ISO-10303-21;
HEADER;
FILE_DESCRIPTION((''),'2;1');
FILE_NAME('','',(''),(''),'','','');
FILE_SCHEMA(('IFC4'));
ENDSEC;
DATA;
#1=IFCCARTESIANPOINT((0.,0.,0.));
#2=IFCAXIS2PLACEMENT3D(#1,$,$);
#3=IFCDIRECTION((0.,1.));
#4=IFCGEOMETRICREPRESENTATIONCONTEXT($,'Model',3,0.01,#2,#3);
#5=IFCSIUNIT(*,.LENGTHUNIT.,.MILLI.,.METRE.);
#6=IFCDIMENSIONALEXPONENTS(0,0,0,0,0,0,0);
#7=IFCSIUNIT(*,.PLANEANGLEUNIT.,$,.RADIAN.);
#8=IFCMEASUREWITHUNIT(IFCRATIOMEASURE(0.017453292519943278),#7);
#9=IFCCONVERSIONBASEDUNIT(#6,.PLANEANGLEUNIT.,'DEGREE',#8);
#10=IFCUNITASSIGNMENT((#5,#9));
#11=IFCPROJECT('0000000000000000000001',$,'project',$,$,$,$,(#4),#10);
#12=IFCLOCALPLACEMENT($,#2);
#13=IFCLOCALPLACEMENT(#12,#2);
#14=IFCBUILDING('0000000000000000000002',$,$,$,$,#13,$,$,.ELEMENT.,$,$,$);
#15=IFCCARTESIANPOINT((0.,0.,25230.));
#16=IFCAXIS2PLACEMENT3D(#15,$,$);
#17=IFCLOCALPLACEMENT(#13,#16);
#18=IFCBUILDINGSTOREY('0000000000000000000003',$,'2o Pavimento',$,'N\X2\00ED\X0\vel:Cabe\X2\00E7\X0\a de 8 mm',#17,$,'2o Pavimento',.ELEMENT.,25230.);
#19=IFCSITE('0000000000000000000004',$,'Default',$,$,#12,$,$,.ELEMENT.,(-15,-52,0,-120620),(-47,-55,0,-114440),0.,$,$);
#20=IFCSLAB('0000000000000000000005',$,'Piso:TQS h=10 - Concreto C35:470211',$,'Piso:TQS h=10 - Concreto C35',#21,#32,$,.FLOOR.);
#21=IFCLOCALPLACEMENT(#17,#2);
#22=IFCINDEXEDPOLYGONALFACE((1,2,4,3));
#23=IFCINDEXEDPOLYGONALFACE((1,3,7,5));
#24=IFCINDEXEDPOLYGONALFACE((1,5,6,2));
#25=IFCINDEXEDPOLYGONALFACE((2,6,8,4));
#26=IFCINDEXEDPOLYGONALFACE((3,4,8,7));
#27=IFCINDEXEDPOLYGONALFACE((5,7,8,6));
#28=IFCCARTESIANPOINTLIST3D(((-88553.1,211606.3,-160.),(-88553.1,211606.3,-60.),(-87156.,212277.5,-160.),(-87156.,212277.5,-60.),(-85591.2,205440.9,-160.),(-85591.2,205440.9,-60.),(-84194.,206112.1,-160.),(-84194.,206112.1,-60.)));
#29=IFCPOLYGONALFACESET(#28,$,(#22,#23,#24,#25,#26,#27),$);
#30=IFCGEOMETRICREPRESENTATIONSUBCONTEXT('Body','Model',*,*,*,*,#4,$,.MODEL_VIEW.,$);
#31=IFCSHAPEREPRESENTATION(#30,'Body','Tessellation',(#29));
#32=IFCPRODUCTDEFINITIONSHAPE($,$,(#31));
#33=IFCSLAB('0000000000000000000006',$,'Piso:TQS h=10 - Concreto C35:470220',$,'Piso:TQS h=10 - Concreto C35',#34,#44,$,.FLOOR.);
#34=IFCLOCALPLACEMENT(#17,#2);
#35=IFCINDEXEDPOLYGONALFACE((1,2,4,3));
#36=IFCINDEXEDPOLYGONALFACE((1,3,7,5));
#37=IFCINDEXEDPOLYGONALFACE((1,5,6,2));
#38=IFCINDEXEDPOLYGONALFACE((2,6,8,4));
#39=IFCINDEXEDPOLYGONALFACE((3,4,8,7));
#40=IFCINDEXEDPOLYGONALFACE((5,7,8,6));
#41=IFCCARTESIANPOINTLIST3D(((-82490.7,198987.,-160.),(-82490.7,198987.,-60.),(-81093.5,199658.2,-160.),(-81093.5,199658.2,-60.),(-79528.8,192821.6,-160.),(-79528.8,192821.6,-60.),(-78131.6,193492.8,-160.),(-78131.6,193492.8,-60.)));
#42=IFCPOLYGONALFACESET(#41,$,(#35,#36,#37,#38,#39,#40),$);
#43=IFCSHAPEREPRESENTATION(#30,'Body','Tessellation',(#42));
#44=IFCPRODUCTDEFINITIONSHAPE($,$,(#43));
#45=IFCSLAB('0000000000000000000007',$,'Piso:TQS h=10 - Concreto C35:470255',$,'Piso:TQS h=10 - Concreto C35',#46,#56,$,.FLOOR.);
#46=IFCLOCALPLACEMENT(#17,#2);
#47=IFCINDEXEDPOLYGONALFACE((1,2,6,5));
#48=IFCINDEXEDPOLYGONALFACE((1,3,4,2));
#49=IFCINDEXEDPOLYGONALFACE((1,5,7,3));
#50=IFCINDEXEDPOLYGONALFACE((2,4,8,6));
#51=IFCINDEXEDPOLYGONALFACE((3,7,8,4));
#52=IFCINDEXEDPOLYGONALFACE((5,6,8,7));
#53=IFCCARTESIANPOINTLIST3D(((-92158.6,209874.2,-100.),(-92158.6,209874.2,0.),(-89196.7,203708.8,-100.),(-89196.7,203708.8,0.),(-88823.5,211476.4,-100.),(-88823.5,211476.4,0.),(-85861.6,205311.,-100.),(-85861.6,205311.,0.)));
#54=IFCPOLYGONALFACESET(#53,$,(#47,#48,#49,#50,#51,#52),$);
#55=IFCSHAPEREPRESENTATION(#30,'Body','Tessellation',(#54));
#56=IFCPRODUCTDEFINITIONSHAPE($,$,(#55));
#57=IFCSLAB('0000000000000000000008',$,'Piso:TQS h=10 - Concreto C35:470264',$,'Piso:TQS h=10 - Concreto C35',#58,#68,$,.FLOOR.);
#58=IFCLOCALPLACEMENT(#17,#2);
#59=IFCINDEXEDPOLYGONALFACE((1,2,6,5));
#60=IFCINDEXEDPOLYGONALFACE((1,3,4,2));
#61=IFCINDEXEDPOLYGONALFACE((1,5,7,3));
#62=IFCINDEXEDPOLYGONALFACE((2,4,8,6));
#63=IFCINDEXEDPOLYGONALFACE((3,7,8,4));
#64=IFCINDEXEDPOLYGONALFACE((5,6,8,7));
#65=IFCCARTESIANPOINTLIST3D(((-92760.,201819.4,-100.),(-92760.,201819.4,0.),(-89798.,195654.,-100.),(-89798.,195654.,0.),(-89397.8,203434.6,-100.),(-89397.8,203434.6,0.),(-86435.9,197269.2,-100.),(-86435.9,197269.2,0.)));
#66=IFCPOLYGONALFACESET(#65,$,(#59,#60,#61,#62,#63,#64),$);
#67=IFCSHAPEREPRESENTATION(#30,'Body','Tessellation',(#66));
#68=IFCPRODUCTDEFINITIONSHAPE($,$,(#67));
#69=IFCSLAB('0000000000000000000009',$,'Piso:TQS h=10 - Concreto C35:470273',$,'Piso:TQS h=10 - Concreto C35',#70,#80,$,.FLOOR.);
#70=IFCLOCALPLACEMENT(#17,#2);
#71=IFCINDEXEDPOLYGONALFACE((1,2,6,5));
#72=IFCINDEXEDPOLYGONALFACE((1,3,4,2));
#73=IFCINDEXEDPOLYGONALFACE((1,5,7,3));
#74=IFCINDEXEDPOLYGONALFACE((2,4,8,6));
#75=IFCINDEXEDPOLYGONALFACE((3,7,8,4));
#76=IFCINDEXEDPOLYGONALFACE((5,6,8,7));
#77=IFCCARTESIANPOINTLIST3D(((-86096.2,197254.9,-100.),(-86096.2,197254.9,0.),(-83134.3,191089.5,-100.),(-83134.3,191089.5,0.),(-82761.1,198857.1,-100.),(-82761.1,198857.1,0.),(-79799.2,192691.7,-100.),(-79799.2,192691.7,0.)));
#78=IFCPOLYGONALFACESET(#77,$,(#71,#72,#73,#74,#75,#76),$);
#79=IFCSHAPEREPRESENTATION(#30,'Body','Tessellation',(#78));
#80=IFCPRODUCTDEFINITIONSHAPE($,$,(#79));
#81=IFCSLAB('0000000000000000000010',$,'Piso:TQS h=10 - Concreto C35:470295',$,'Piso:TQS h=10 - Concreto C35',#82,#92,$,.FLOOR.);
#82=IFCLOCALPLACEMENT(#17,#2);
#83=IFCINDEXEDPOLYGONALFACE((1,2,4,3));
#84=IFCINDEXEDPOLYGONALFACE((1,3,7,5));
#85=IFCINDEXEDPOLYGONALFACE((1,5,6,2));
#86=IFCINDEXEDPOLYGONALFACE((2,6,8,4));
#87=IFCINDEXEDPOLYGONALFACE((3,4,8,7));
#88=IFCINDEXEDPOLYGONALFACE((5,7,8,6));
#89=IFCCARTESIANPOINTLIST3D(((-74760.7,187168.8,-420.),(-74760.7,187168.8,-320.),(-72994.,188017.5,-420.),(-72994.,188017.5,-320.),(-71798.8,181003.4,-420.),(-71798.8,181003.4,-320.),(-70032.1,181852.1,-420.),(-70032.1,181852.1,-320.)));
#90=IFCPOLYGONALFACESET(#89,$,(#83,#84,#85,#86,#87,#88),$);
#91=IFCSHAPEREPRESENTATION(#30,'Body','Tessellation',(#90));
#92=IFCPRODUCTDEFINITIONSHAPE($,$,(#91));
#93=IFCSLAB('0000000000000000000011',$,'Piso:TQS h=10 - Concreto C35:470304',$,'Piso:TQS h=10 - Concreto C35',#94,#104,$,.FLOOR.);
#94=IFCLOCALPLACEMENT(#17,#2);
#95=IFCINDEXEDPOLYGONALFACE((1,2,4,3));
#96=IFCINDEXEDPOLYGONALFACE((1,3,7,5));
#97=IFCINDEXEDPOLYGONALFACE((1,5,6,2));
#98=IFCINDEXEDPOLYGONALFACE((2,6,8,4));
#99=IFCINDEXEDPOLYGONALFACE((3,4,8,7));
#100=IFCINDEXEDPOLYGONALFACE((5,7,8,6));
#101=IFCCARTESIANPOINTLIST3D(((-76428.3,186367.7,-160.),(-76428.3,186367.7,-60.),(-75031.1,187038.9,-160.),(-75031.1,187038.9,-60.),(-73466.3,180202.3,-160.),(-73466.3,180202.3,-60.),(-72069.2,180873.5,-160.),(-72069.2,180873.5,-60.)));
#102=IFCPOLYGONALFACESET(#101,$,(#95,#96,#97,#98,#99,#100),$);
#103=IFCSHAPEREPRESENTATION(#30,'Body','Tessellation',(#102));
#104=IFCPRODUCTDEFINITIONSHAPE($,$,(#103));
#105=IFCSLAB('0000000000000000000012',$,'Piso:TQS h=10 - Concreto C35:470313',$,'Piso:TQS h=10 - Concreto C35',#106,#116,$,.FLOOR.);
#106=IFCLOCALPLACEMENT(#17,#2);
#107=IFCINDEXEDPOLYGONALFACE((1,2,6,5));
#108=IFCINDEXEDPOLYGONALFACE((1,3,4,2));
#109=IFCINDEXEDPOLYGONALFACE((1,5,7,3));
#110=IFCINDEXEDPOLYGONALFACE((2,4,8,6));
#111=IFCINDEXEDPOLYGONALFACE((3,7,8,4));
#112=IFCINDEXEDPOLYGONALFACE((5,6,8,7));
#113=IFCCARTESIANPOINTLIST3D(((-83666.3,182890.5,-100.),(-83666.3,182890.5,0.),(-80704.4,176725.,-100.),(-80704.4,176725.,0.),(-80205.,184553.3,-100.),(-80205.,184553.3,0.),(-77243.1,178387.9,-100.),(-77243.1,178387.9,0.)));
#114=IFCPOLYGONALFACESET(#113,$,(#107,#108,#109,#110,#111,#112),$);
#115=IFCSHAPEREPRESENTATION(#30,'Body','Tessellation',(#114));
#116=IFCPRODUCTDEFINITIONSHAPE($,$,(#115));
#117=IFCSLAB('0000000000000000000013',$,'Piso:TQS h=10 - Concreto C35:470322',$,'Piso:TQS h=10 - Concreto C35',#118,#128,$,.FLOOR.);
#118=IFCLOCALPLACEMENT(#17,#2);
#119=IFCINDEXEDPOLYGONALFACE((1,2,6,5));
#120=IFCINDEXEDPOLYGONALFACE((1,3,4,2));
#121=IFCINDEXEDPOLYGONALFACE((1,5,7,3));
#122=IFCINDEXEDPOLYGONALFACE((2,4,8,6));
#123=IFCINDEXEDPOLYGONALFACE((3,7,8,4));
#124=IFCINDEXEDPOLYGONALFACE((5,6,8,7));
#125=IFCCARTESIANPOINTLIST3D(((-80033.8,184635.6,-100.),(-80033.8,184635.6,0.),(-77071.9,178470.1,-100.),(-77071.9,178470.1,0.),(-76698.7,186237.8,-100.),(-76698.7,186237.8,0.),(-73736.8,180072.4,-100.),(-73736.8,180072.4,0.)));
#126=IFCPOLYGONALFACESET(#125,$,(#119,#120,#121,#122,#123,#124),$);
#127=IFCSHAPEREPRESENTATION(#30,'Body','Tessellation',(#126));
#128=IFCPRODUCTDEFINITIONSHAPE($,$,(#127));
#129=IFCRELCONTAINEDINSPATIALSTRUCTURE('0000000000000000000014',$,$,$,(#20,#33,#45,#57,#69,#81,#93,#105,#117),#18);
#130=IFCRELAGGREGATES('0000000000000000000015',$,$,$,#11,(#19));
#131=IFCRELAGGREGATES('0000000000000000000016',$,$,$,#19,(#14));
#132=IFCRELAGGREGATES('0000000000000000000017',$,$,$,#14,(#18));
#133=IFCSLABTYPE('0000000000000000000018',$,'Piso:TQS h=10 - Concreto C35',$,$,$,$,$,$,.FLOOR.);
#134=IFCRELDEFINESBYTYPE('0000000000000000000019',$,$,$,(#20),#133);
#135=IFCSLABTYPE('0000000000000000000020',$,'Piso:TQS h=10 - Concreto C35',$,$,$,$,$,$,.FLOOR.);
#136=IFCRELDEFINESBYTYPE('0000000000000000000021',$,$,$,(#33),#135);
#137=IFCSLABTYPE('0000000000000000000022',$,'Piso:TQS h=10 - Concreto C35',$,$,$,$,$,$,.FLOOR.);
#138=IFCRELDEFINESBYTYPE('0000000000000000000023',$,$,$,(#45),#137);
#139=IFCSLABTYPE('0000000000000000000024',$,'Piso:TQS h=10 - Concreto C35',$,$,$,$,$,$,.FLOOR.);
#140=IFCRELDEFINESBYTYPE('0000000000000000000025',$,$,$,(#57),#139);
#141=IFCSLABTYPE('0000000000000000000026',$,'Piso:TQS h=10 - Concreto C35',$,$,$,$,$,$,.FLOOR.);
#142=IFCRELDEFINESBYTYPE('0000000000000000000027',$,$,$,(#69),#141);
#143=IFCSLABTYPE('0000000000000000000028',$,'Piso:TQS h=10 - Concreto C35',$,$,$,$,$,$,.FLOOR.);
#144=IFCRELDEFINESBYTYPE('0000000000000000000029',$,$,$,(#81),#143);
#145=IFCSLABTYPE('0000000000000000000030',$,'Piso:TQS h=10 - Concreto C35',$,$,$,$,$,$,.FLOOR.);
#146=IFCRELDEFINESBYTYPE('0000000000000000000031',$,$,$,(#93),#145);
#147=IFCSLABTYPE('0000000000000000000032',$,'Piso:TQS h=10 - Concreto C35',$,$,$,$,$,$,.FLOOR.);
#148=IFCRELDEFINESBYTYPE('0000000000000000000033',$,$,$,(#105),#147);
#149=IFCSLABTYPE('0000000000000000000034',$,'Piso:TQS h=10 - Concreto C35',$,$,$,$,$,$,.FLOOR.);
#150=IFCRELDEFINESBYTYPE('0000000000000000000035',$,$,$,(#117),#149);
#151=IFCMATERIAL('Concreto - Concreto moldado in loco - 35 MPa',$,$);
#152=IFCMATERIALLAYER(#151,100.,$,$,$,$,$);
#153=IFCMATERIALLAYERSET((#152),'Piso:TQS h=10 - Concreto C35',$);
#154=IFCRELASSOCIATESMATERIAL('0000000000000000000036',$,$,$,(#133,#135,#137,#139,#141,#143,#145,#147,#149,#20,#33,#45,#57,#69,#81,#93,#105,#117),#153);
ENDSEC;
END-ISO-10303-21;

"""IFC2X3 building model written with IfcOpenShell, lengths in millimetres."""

from ifc_helpers import new_model, entity, si_unit, converted_unit, direction, frame, frame_2d, origin, place, context, subcontext, project, spatial, rectangle, extrude, material, layer, layer_set, layer_usage, type_object, element, save


model = new_model("IFC2X3")

# Units and contexts
model_context = context("Model", 3, precision=0.01, world=origin(), true_north=direction((0.0, 1.0)))
body_context = subcontext(model_context, "Body", "Model", "MODEL_VIEW")
ifc_project = project(units=[si_unit("LENGTHUNIT", "METRE", prefix="MILLI"), converted_unit("PLANEANGLEUNIT", "DEGREE", entity("IfcRatioMeasure", 0.017453292519943278), si_unit("PLANEANGLEUNIT", "RADIAN"), dimensions=[0, 0, 0, 0, 0, 0, 0])], contexts=[model_context])

# Site, building, storey
site_placement = place(None, origin())
site = spatial("IfcSite", under=ifc_project, at=site_placement, Name="Default", CompositionType="ELEMENT", RefLatitude=(-15, -52, 0, -120620), RefLongitude=(-47, -55, 0, -114440), RefElevation=0.0)
building_placement = place(site_placement, origin())
building = spatial("IfcBuilding", under=site, at=building_placement, CompositionType="ELEMENT")
storey_placement = place(building_placement, frame((0.0, 0.0, 25230.0)))
storey = spatial("IfcBuildingStorey", under=building, at=storey_placement, Name="2o Pavimento", ObjectType="Nível:Cabeça de 8 mm", LongName="2o Pavimento", CompositionType="ELEMENT", Elevation=25230.0)

# Shared definitions
ifc_material = material(Name="Concreto - Concreto moldado in loco - 35 MPa")

# Slabs
ifc_layer_1 = layer(ifc_material, 100.0)
ifc_layer_set_1 = layer_set([ifc_layer_1], Name="Piso:TQS h=10 - Concreto C35")
ifc_layer_usage_1 = layer_usage(ifc_layer_set_1, "AXIS3", "POSITIVE", 0.0)
slab_type_1 = type_object("IfcSlabType", Name="Piso:TQS h=10 - Concreto C35", PredefinedType="FLOOR", material=ifc_layer_set_1)
slab_1_placement = place(storey_placement, origin())
element("IfcSlab", 1, at=slab_1_placement, inside=storey, type_object=slab_type_1, material=ifc_layer_usage_1, Name="Piso:TQS h=10 - Concreto C35:470211", ObjectType="Piso:TQS h=10 - Concreto C35", PredefinedType="FLOOR", context=body_context, shape_type="SweptSolid", body=[
    extrude(rectangle(XDim=6840.0, YDim=1550.0, at=frame_2d((0.0, 0.0), x_axis=(1.0, 0.0))), frame((-86373.6, 208859.2, -60.0), z_axis=(0.0, 0.0, -1.0), x_axis=(0.43303, -0.90138, 0.0)), (0.0, 0.0, 1.0), 100.0),
])
ifc_layer_usage_2 = layer_usage(ifc_layer_set_1, "AXIS3", "POSITIVE", 0.0)
slab_type_2 = type_object("IfcSlabType", Name="Piso:TQS h=10 - Concreto C35", PredefinedType="FLOOR", material=ifc_layer_set_1)
slab_2_placement = place(storey_placement, origin())
element("IfcSlab", 2, at=slab_2_placement, inside=storey, type_object=slab_type_2, material=ifc_layer_usage_2, Name="Piso:TQS h=10 - Concreto C35:470220", ObjectType="Piso:TQS h=10 - Concreto C35", PredefinedType="FLOOR", context=body_context, shape_type="SweptSolid", body=[
    extrude(rectangle(XDim=6840.0, YDim=1550.0, at=frame_2d((0.0, 0.0), x_axis=(1.0, 0.0))), frame((-80311.1, 196239.9, -60.0), z_axis=(0.0, 0.0, -1.0), x_axis=(0.43303, -0.90138, 0.0)), (0.0, 0.0, 1.0), 100.0),
])
ifc_layer_usage_3 = layer_usage(ifc_layer_set_1, "AXIS3", "POSITIVE", 0.0)
slab_type_3 = type_object("IfcSlabType", Name="Piso:TQS h=10 - Concreto C35", PredefinedType="FLOOR", material=ifc_layer_set_1)
slab_3_placement = place(storey_placement, origin())
element("IfcSlab", 3, at=slab_3_placement, inside=storey, type_object=slab_type_3, material=ifc_layer_usage_3, Name="Piso:TQS h=10 - Concreto C35:470255", ObjectType="Piso:TQS h=10 - Concreto C35", PredefinedType="FLOOR", context=body_context, shape_type="SweptSolid", body=[
    extrude(rectangle(XDim=6840.0, YDim=3700.0, at=frame_2d((0.0, 0.0), x_axis=(1.0, 0.0))), frame((-89010.1, 207592.6, 0.0), z_axis=(0.0, 0.0, -1.0), x_axis=(0.43303, -0.90138, 0.0)), (0.0, 0.0, 1.0), 100.0),
])
ifc_layer_usage_4 = layer_usage(ifc_layer_set_1, "AXIS3", "POSITIVE", 0.0)
slab_type_4 = type_object("IfcSlabType", Name="Piso:TQS h=10 - Concreto C35", PredefinedType="FLOOR", material=ifc_layer_set_1)
slab_4_placement = place(storey_placement, origin())
element("IfcSlab", 4, at=slab_4_placement, inside=storey, type_object=slab_type_4, material=ifc_layer_usage_4, Name="Piso:TQS h=10 - Concreto C35:470264", ObjectType="Piso:TQS h=10 - Concreto C35", PredefinedType="FLOOR", context=body_context, shape_type="SweptSolid", body=[
    extrude(rectangle(XDim=6840.0, YDim=3730.0, at=frame_2d((0.0, 0.0), x_axis=(1.0, 0.0))), frame((-89597.9, 199544.3, 0.0), z_axis=(0.0, 0.0, -1.0), x_axis=(0.43303, -0.90138, 0.0)), (0.0, 0.0, 1.0), 100.0),
])
ifc_layer_usage_5 = layer_usage(ifc_layer_set_1, "AXIS3", "POSITIVE", 0.0)
slab_type_5 = type_object("IfcSlabType", Name="Piso:TQS h=10 - Concreto C35", PredefinedType="FLOOR", material=ifc_layer_set_1)
slab_5_placement = place(storey_placement, origin())
element("IfcSlab", 5, at=slab_5_placement, inside=storey, type_object=slab_type_5, material=ifc_layer_usage_5, Name="Piso:TQS h=10 - Concreto C35:470273", ObjectType="Piso:TQS h=10 - Concreto C35", PredefinedType="FLOOR", context=body_context, shape_type="SweptSolid", body=[
    extrude(rectangle(XDim=6840.0, YDim=3700.0, at=frame_2d((0.0, 0.0), x_axis=(1.0, 0.0))), frame((-82947.7, 194973.3, 0.0), z_axis=(0.0, 0.0, -1.0), x_axis=(0.43303, -0.90138, 0.0)), (0.0, 0.0, 1.0), 100.0),
])
ifc_layer_usage_6 = layer_usage(ifc_layer_set_1, "AXIS3", "POSITIVE", 0.0)
slab_type_6 = type_object("IfcSlabType", Name="Piso:TQS h=10 - Concreto C35", PredefinedType="FLOOR", material=ifc_layer_set_1)
slab_6_placement = place(storey_placement, origin())
element("IfcSlab", 6, at=slab_6_placement, inside=storey, type_object=slab_type_6, material=ifc_layer_usage_6, Name="Piso:TQS h=10 - Concreto C35:470295", ObjectType="Piso:TQS h=10 - Concreto C35", PredefinedType="FLOOR", context=body_context, shape_type="SweptSolid", body=[
    extrude(rectangle(XDim=6840.0, YDim=1960.0, at=frame_2d((0.0, 0.0), x_axis=(1.0, 0.0))), frame((-72396.4, 184510.5, -320.0), z_axis=(0.0, 0.0, -1.0), x_axis=(0.43303, -0.90138, 0.0)), (0.0, 0.0, 1.0), 100.0),
])
ifc_layer_usage_7 = layer_usage(ifc_layer_set_1, "AXIS3", "POSITIVE", 0.0)
slab_type_7 = type_object("IfcSlabType", Name="Piso:TQS h=10 - Concreto C35", PredefinedType="FLOOR", material=ifc_layer_set_1)
slab_7_placement = place(storey_placement, origin())
element("IfcSlab", 7, at=slab_7_placement, inside=storey, type_object=slab_type_7, material=ifc_layer_usage_7, Name="Piso:TQS h=10 - Concreto C35:470304", ObjectType="Piso:TQS h=10 - Concreto C35", PredefinedType="FLOOR", context=body_context, shape_type="SweptSolid", body=[
    extrude(rectangle(XDim=1550.0, YDim=6840.0, at=frame_2d((0.0, 0.0), x_axis=(1.0, 0.0))), frame((-74248.7, 183620.6, -60.0), z_axis=(0.0, 0.0, -1.0), x_axis=(0.90138, 0.43303, 0.0)), (0.0, 0.0, 1.0), 100.0),
])
ifc_layer_usage_8 = layer_usage(ifc_layer_set_1, "AXIS3", "POSITIVE", 0.0)
slab_type_8 = type_object("IfcSlabType", Name="Piso:TQS h=10 - Concreto C35", PredefinedType="FLOOR", material=ifc_layer_set_1)
slab_8_placement = place(storey_placement, origin())
element("IfcSlab", 8, at=slab_8_placement, inside=storey, type_object=slab_type_8, material=ifc_layer_usage_8, Name="Piso:TQS h=10 - Concreto C35:470313", ObjectType="Piso:TQS h=10 - Concreto C35", PredefinedType="FLOOR", context=body_context, shape_type="SweptSolid", body=[
    extrude(rectangle(XDim=3840.0, YDim=6840.0, at=frame_2d((0.0, 0.0), x_axis=(1.0, 0.0))), frame((-80454.7, 180639.2, 0.0), z_axis=(0.0, 0.0, -1.0), x_axis=(0.90138, 0.43303, 0.0)), (0.0, 0.0, 1.0), 100.0),
])
ifc_layer_usage_9 = layer_usage(ifc_layer_set_1, "AXIS3", "POSITIVE", 0.0)
slab_type_9 = type_object("IfcSlabType", Name="Piso:TQS h=10 - Concreto C35", PredefinedType="FLOOR", material=ifc_layer_set_1)
slab_9_placement = place(storey_placement, origin())
element("IfcSlab", 9, at=slab_9_placement, inside=storey, type_object=slab_type_9, material=ifc_layer_usage_9, Name="Piso:TQS h=10 - Concreto C35:470322", ObjectType="Piso:TQS h=10 - Concreto C35", PredefinedType="FLOOR", context=body_context, shape_type="SweptSolid", body=[
    extrude(rectangle(XDim=6840.0, YDim=3700.0, at=frame_2d((0.0, 0.0), x_axis=(1.0, 0.0))), frame((-76885.3, 182354.0, 0.0), z_axis=(0.0, 0.0, -1.0), x_axis=(0.43303, -0.90138, 0.0)), (0.0, 0.0, 1.0), 100.0),
])

save(model, "model.ifc")
